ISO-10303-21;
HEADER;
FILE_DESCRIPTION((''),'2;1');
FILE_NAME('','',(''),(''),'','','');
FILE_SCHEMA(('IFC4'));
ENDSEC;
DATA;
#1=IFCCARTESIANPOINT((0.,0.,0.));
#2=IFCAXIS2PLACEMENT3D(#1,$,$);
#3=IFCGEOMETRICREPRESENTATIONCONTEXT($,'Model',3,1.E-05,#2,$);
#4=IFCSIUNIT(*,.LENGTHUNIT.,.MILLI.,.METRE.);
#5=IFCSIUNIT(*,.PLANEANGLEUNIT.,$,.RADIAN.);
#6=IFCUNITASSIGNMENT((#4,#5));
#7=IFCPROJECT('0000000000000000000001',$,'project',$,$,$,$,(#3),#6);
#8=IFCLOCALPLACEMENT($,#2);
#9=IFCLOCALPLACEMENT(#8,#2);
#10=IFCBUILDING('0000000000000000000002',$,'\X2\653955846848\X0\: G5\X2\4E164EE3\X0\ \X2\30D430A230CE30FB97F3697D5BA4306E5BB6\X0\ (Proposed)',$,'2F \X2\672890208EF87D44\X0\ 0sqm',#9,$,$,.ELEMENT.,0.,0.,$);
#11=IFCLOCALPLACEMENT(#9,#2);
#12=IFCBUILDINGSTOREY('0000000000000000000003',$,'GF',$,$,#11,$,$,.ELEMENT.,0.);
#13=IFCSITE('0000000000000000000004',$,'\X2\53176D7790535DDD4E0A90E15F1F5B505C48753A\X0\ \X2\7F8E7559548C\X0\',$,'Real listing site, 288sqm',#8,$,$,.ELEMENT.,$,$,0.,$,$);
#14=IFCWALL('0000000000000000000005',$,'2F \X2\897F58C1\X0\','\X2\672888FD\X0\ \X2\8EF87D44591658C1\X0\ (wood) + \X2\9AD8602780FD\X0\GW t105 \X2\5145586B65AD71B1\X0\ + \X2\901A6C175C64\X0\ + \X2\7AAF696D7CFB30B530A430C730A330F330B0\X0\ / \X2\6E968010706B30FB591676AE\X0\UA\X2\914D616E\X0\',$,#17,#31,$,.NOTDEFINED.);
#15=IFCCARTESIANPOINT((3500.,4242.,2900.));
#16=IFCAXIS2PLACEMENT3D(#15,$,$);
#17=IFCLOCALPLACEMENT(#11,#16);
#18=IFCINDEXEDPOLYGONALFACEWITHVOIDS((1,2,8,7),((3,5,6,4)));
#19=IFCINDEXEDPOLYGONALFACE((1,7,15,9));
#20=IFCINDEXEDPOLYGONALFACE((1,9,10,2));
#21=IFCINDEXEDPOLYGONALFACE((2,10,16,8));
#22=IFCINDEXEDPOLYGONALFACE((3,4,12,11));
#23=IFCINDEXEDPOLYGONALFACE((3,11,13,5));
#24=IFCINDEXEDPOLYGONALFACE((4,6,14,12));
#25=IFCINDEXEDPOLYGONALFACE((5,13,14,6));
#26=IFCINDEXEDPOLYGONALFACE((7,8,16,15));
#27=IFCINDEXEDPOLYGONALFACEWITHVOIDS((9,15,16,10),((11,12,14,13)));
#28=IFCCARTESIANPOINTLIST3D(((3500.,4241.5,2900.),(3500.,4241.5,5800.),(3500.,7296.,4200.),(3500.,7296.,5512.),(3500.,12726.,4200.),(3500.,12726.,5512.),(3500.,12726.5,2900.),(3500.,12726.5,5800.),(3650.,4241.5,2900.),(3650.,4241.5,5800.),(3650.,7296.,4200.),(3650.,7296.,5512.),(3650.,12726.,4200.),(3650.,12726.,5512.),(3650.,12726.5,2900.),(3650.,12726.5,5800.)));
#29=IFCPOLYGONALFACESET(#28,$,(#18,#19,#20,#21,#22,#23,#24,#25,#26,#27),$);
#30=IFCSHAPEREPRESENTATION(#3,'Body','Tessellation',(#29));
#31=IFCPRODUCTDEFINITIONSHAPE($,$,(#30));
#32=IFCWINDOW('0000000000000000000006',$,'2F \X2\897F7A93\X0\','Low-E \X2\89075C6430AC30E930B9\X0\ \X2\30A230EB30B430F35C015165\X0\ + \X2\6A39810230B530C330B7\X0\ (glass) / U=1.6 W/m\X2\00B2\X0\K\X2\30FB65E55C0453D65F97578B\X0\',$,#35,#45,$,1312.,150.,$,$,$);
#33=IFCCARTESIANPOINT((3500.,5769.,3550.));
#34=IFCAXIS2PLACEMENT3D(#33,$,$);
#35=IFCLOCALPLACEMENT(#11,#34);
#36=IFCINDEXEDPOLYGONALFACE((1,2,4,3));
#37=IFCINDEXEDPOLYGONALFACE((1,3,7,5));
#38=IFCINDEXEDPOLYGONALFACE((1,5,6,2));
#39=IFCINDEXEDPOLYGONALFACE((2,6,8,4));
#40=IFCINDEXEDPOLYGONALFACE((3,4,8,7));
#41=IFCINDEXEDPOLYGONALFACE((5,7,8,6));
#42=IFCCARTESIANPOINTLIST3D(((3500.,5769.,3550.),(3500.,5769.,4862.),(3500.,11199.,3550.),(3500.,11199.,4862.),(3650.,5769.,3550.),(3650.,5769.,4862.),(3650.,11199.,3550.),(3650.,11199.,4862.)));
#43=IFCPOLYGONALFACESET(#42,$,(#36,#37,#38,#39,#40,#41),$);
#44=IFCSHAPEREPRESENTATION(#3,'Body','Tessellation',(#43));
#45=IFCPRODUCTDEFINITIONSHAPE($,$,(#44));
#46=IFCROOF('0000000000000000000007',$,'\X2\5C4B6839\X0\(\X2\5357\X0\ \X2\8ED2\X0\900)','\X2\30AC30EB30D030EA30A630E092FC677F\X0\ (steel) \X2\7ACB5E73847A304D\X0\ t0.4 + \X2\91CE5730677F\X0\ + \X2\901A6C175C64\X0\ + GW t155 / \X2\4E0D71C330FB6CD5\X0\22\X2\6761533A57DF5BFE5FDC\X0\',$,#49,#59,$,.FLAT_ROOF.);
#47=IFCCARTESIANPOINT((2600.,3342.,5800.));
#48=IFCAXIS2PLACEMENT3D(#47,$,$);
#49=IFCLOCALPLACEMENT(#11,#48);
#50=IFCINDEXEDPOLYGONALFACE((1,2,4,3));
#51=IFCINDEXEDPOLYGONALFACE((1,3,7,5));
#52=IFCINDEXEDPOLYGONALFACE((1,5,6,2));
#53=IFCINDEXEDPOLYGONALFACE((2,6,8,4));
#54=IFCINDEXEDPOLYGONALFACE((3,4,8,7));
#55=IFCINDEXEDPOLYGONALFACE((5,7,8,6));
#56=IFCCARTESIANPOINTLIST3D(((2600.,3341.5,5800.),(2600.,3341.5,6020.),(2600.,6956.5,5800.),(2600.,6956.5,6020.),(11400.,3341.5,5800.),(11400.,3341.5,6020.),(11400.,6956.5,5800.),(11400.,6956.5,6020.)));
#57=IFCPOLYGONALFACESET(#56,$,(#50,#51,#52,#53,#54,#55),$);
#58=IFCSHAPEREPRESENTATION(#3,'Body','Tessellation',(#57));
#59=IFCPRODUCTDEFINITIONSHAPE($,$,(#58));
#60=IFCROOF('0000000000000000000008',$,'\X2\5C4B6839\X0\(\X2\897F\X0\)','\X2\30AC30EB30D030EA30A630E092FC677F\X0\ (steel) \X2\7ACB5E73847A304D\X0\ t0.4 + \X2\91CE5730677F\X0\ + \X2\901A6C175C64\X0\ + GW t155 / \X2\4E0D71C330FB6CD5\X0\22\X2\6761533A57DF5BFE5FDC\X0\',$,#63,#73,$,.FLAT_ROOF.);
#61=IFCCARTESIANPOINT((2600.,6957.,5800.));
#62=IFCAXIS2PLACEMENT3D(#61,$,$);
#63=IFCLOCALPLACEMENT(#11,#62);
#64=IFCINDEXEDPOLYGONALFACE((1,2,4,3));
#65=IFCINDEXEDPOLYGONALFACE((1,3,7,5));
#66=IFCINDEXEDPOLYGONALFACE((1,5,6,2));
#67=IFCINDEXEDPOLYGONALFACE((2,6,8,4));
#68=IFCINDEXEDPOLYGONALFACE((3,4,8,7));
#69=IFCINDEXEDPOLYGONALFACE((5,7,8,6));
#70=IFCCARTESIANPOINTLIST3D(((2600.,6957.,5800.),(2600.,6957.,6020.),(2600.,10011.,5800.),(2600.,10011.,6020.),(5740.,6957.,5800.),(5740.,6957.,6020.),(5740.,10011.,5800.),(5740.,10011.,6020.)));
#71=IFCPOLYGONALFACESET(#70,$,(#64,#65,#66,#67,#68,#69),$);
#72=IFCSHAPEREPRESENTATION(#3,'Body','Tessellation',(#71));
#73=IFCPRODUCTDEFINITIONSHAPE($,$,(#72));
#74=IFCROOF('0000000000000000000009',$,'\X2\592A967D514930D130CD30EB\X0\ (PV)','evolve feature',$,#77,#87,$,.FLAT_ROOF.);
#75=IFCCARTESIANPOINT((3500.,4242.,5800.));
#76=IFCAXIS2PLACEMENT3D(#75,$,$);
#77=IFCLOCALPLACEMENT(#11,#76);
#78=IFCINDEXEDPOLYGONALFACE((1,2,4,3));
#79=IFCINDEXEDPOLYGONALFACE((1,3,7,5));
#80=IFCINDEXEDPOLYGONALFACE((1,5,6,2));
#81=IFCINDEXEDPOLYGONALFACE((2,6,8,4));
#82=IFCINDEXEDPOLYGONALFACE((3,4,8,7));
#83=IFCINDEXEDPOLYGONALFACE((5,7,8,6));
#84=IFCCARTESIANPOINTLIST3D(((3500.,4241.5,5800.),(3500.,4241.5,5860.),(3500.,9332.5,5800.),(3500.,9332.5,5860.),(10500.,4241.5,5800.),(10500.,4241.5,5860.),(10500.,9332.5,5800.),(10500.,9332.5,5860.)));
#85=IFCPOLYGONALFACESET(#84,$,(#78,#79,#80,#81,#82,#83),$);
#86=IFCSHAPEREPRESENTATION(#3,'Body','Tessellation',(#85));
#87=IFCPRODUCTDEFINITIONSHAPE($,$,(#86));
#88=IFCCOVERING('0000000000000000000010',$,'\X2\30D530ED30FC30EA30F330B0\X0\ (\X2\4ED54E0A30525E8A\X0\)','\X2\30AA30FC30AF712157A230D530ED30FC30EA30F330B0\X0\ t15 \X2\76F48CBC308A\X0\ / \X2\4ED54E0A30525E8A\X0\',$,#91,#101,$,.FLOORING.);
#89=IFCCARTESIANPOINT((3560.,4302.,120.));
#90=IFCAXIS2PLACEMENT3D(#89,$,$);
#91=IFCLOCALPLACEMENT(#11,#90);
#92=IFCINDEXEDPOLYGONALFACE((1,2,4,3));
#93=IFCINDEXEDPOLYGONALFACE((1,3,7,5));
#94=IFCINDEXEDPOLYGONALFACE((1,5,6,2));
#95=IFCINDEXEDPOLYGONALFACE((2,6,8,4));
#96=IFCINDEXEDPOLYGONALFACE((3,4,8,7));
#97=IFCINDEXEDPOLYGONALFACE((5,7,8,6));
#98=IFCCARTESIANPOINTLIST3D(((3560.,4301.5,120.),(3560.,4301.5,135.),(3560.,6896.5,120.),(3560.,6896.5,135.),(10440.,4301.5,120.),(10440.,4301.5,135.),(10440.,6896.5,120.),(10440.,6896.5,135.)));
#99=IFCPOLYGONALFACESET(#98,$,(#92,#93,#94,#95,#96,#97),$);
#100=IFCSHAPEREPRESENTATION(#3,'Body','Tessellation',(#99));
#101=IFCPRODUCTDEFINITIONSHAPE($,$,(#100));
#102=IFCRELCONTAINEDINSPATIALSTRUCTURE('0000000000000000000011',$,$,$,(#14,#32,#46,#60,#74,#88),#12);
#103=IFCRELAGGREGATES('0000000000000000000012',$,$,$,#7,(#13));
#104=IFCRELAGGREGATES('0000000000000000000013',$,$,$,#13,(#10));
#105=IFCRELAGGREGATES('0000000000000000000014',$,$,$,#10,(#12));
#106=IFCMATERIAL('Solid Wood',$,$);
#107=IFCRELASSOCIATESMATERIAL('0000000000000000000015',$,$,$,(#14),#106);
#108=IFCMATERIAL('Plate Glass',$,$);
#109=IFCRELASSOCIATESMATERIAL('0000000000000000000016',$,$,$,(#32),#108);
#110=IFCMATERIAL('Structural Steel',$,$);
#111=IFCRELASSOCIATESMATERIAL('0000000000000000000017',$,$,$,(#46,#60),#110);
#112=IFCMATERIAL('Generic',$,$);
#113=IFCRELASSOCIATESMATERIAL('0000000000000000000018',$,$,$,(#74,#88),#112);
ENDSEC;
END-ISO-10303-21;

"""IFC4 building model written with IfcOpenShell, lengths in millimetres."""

from ifc_helpers import new_model, si_unit, frame, frame_2d, origin, place, context, project, spatial, rectangle, extrude, material, element, fill, save


model = new_model("IFC4")

# Units and contexts
model_context = context("Model", 3, precision=1e-05, world=origin())
ifc_project = project(units=[si_unit("LENGTHUNIT", "METRE", prefix="MILLI"), si_unit("PLANEANGLEUNIT", "RADIAN")], contexts=[model_context])

# Site, building, storey
site_placement = place(None, origin())
site = spatial("IfcSite", under=ifc_project, at=site_placement, Name="北海道川上郡弟子屈町 美留和", ObjectType="Real listing site, 288sqm", CompositionType="ELEMENT", RefElevation=0.0)
building_placement = place(site_placement, origin())
building = spatial("IfcBuilding", under=site, at=building_placement, Name="改善案: G5世代 ピアノ・音楽室の家 (Proposed)", ObjectType="2F 木造軸組 0sqm", CompositionType="ELEMENT", ElevationOfRefHeight=0.0, ElevationOfTerrain=0.0)
storey_placement = place(building_placement, origin())
storey = spatial("IfcBuildingStorey", under=building, at=storey_placement, Name="GF", CompositionType="ELEMENT", Elevation=0.0)

# Shared definitions
ifc_material_1 = material(Name="Solid Wood")
ifc_material_2 = material(Name="Generic")

# Shared definitions
ifc_material_3 = material(Name="Plate Glass")

# Wall, opening, window
wall_1_placement = place(storey_placement, frame((3500.0, 4242.0, 2900.0)))
wall_1 = element("IfcWall", 1, at=wall_1_placement, inside=storey, material=ifc_material_1, Name="2F 西壁", Description="木製 軸組外壁 (wood) + 高性能GW t105 充填断熱 + 通気層 + 窯業系サイディング / 準耐火・外皮UA配慮", PredefinedType="NOTDEFINED", context=model_context, shape_type="SweptSolid", body=[
    extrude(rectangle(XDim=150.0, YDim=8485.0, at=frame_2d((75.0, 4242.0))), frame((3500.0, 4242.0, 2900.0)), (0.0, 0.0, 1.0), 2900.0),
])
opening_1_placement = place(storey_placement, frame((3500.0, 5769.0, 3550.0)))
opening_1 = element("IfcOpeningElement", 2, at=opening_1_placement, cuts=wall_1, PredefinedType="NOTDEFINED", context=model_context, shape_type="SweptSolid", body=[
    extrude(rectangle(XDim=150.0, YDim=5430.0, at=frame_2d((75.0, 2715.0))), frame((3500.0, 5769.0, 3550.0)), (0.0, 0.0, 1.0), 1312.0),
])
window_1_placement = place(storey_placement, frame((3500.0, 5769.0, 3550.0)))
window_1 = element("IfcWindow", 3, at=window_1_placement, inside=storey, material=ifc_material_3, Name="2F 西窓", Description="Low-E 複層ガラス アルゴン封入 + 樹脂サッシ (glass) / U=1.6 W/m²K・日射取得型", OverallHeight=1312.0, OverallWidth=150.0, context=model_context, shape_type="SweptSolid", body=[
    extrude(rectangle(XDim=150.0, YDim=5430.0, at=frame_2d((75.0, 2715.0))), frame((3500.0, 5769.0, 3550.0)), (0.0, 0.0, 1.0), 1312.0),
])
fill(opening_1, window_1)

# Roofs
ifc_material_4 = material(Name="Structural Steel")
roof_1_placement = place(storey_placement, frame((2600.0, 3342.0, 5800.0)))
element("IfcRoof", 4, at=roof_1_placement, inside=storey, material=ifc_material_4, Name="屋根(南 軒900)", Description="ガルバリウム鋼板 (steel) 立平葺き t0.4 + 野地板 + 通気層 + GW t155 / 不燃・法22条区域対応", PredefinedType="FLAT_ROOF", context=model_context, shape_type="SweptSolid", body=[
    extrude(rectangle(XDim=8800.0, YDim=3615.0, at=frame_2d((4400.0, 1807.0))), frame((2600.0, 3342.0, 5800.0)), (0.0, 0.0, 1.0), 220.0),
])
roof_2_placement = place(storey_placement, frame((2600.0, 6957.0, 5800.0)))
element("IfcRoof", 5, at=roof_2_placement, inside=storey, material=ifc_material_4, Name="屋根(西)", Description="ガルバリウム鋼板 (steel) 立平葺き t0.4 + 野地板 + 通気層 + GW t155 / 不燃・法22条区域対応", PredefinedType="FLAT_ROOF", context=model_context, shape_type="SweptSolid", body=[
    extrude(rectangle(XDim=3140.0, YDim=3054.0, at=frame_2d((1570.0, 1527.0))), frame((2600.0, 6957.0, 5800.0)), (0.0, 0.0, 1.0), 220.0),
])
roof_3_placement = place(storey_placement, frame((3500.0, 4242.0, 5800.0)))
element("IfcRoof", 6, at=roof_3_placement, inside=storey, material=ifc_material_2, Name="太陽光パネル (PV)", Description="evolve feature", PredefinedType="FLAT_ROOF", context=model_context, shape_type="SweptSolid", body=[
    extrude(rectangle(XDim=7000.0, YDim=5091.0, at=frame_2d((3500.0, 2545.0))), frame((3500.0, 4242.0, 5800.0)), (0.0, 0.0, 1.0), 60.0),
])

# Covering
covering_placement = place(storey_placement, frame((3560.0, 4302.0, 120.0)))
element("IfcCovering", 7, at=covering_placement, inside=storey, material=ifc_material_2, Name="フローリング (仕上げ床)", Description="オーク無垢フローリング t15 直貼り / 仕上げ床", PredefinedType="FLOORING", context=model_context, shape_type="SweptSolid", body=[
    extrude(rectangle(XDim=6880.0, YDim=2595.0, at=frame_2d((3440.0, 1297.0))), frame((3560.0, 4302.0, 120.0)), (0.0, 0.0, 1.0), 15.0),
])

save(model, "model.ifc")
